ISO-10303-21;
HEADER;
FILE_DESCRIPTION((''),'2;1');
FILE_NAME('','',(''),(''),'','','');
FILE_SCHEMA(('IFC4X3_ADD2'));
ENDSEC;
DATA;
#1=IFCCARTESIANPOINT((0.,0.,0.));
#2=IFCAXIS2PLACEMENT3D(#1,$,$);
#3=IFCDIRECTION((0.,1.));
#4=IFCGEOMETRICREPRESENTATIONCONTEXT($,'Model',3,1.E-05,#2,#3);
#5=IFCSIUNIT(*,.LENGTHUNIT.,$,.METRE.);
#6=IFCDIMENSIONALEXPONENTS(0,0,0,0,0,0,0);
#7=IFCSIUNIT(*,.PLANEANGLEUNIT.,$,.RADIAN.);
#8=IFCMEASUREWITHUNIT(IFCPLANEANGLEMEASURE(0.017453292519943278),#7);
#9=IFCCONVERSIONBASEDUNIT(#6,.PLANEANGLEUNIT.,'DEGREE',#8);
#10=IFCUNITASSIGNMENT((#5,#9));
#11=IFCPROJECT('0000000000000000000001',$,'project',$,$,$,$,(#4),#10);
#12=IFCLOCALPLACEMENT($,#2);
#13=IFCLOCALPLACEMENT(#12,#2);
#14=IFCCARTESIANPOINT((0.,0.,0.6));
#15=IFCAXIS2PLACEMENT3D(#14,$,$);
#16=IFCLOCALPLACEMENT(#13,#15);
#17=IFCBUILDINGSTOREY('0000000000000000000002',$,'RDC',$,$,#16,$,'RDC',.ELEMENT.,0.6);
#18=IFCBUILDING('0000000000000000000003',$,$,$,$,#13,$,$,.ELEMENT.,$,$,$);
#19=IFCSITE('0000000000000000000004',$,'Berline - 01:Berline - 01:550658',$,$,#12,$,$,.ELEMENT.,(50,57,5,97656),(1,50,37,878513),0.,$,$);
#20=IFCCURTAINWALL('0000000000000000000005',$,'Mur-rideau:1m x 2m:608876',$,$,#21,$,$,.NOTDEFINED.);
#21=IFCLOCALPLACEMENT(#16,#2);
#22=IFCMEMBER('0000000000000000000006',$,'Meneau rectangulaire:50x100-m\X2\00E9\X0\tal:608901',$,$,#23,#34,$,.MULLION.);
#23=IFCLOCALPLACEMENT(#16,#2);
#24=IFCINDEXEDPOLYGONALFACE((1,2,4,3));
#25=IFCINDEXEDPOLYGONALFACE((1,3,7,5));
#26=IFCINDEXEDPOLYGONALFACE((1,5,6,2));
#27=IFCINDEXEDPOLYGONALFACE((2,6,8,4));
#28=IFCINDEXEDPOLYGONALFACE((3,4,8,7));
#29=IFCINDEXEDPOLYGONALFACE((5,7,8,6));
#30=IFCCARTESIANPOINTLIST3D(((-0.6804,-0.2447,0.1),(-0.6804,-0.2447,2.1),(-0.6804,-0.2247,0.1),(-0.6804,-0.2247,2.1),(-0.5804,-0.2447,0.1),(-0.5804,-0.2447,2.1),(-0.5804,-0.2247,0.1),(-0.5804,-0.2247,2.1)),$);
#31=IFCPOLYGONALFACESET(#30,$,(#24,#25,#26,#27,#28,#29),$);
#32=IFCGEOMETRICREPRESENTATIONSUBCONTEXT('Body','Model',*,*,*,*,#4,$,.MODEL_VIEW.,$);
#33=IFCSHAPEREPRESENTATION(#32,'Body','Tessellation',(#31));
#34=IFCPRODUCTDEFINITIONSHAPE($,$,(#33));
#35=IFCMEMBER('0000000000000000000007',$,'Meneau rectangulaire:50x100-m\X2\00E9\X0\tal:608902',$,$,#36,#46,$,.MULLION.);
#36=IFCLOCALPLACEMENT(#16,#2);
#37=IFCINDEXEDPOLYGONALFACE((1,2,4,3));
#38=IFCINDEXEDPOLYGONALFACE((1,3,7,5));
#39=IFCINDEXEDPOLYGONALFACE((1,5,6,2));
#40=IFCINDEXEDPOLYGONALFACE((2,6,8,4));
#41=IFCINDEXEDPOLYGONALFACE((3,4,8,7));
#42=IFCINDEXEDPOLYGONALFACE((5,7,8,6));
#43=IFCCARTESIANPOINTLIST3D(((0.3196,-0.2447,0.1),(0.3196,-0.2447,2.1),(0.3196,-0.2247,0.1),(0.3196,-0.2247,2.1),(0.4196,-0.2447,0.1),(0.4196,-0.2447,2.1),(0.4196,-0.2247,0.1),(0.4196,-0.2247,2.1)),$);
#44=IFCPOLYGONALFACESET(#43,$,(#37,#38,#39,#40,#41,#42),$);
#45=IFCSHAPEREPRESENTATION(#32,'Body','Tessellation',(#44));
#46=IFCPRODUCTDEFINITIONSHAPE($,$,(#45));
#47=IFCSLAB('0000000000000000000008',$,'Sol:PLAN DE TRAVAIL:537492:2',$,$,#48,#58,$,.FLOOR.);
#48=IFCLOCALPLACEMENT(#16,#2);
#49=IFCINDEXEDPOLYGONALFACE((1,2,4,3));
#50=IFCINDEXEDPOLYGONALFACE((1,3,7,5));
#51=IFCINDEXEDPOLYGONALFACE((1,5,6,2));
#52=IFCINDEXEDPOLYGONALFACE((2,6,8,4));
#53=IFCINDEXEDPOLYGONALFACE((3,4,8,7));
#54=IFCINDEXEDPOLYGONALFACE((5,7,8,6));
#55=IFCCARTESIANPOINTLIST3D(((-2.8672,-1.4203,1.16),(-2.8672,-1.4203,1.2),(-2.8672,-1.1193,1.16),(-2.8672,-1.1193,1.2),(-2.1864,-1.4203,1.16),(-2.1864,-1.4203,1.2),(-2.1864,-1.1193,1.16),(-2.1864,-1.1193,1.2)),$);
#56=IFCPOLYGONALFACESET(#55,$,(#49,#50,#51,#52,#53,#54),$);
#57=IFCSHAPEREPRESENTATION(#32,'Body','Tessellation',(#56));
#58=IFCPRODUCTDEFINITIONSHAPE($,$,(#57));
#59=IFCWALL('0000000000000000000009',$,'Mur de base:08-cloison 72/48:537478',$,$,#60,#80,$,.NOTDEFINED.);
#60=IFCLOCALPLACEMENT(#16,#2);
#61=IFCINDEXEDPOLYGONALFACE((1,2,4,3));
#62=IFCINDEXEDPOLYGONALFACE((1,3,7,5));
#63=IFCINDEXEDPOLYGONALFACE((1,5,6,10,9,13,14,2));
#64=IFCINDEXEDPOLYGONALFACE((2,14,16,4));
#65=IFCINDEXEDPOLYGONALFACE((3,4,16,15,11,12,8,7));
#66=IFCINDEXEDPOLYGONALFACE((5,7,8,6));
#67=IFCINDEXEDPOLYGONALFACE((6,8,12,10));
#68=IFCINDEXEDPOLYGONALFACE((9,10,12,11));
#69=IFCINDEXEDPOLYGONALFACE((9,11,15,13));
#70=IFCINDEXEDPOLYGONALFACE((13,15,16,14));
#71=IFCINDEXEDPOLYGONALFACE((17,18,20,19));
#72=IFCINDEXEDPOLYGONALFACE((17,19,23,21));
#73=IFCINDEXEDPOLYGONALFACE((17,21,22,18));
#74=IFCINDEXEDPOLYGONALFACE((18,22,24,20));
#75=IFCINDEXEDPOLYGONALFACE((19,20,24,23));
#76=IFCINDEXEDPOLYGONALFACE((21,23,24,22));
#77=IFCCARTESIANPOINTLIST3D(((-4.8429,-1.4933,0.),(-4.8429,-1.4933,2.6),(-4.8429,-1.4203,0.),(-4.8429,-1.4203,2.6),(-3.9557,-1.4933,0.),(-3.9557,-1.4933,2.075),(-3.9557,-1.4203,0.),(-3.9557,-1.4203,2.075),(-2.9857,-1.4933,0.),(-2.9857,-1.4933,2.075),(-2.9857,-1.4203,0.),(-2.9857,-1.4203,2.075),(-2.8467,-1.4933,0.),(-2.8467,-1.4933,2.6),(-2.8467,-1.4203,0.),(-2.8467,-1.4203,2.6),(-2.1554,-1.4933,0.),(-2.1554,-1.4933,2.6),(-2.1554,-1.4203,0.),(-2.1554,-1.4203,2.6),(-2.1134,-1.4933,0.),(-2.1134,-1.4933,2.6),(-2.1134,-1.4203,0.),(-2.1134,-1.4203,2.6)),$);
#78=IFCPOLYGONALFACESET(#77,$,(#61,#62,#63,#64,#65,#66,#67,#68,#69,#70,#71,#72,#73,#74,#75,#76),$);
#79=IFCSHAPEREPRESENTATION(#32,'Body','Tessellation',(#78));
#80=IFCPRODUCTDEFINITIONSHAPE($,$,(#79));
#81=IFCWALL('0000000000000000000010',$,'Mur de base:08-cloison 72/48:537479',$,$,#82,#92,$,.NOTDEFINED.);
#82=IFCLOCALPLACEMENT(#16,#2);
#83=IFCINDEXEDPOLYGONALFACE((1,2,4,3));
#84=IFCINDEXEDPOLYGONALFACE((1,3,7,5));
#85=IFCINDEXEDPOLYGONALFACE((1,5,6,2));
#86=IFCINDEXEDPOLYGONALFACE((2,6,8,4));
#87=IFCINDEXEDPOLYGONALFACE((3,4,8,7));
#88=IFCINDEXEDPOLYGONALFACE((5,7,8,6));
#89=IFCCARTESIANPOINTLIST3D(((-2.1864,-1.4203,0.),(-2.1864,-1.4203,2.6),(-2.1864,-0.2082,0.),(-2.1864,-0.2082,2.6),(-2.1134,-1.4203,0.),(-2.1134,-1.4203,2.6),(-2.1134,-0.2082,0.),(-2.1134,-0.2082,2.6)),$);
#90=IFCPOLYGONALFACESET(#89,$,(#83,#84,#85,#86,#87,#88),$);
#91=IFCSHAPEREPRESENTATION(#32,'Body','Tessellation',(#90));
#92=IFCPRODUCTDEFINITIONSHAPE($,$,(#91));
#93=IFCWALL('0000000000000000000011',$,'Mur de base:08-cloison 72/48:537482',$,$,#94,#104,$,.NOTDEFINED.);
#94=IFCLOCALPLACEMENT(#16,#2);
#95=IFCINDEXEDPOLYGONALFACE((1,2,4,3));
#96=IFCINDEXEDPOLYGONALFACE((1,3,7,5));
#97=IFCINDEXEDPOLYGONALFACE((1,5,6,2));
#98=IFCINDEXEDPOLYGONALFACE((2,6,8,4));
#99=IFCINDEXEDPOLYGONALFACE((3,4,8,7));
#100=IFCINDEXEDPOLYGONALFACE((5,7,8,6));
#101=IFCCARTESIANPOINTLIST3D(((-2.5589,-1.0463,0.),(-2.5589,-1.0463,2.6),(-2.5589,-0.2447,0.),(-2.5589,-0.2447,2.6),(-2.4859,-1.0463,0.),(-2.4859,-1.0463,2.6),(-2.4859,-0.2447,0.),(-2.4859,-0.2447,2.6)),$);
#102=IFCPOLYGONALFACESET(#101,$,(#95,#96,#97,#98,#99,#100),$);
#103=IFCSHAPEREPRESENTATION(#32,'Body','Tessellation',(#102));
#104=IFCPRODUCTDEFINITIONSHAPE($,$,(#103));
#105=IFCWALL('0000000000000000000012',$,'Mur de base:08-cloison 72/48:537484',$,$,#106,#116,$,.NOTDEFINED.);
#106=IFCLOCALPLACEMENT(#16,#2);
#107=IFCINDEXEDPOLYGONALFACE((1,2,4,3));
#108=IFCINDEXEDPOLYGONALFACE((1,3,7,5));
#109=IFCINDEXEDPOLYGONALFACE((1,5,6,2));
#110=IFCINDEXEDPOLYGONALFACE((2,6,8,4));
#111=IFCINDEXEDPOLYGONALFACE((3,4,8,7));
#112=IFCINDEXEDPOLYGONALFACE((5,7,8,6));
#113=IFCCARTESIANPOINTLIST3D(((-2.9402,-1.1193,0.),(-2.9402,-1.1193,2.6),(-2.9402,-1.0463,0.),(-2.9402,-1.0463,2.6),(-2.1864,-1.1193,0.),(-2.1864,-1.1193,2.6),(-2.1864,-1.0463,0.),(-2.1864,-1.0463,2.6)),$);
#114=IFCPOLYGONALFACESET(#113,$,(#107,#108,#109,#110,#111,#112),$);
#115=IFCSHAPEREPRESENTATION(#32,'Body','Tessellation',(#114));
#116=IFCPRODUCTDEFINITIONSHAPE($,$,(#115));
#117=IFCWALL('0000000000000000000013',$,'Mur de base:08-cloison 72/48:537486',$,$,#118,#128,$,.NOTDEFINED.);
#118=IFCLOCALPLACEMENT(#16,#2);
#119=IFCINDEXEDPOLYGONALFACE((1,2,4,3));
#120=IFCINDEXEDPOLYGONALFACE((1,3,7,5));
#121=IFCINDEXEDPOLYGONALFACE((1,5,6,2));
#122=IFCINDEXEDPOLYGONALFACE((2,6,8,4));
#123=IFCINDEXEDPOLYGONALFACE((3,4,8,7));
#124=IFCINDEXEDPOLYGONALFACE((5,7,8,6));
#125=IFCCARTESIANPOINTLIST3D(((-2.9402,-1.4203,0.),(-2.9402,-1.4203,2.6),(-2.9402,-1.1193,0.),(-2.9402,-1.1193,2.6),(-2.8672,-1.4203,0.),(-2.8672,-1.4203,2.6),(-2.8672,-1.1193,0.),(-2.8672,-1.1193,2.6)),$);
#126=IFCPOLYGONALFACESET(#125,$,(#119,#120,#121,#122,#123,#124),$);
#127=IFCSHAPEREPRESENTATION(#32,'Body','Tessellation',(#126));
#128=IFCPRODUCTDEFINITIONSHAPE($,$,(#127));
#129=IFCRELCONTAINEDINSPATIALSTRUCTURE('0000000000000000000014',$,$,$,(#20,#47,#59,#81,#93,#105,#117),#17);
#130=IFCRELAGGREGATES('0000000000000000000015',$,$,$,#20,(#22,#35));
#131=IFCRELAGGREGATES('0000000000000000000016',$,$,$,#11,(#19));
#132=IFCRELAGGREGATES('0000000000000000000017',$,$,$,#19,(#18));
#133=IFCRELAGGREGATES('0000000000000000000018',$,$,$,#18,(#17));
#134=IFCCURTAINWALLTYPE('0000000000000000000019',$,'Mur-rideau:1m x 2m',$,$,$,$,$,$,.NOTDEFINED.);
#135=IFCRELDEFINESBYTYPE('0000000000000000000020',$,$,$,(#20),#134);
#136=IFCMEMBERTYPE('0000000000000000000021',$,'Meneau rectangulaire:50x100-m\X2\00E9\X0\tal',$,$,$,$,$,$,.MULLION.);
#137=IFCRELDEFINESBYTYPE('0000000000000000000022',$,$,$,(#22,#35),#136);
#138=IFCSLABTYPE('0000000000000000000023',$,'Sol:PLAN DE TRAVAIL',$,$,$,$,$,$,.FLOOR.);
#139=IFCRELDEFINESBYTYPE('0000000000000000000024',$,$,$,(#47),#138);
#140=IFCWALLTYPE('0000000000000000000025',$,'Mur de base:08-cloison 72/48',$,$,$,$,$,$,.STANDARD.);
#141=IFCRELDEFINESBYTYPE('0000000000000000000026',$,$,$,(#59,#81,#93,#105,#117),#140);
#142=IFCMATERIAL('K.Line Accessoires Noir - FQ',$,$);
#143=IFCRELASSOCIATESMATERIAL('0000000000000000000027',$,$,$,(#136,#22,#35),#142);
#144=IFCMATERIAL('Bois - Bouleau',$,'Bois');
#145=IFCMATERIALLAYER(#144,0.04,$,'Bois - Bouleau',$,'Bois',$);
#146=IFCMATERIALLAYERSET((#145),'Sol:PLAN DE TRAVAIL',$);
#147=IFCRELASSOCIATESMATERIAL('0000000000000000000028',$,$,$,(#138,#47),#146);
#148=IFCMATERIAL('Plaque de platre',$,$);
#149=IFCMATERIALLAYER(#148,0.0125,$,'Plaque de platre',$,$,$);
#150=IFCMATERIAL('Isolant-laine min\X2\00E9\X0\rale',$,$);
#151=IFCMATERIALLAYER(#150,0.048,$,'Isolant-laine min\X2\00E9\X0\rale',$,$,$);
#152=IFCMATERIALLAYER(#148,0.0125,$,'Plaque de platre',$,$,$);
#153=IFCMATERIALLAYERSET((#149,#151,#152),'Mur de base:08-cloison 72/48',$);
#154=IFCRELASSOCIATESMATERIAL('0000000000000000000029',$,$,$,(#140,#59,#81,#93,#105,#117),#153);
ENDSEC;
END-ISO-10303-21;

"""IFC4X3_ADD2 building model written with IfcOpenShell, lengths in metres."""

from ifc_helpers import new_model, entity, si_unit, converted_unit, direction, frame, frame_2d, origin, origin_2d_with_axis, place, context, subcontext, project, spatial, rectangle, extrude, source, transform, mapped, material, layer, layer_set, layer_usage, material_profile, profile_set, profile_usage, type_object, type_shapes, element, aggregate, save


model = new_model("IFC4X3_ADD2")

# Units and contexts
model_context = context("Model", 3, precision=1e-05, world=origin(), true_north=direction((0.0, 1.0)))
body_context = subcontext(model_context, "Body", "Model", "MODEL_VIEW")
ifc_project = project(units=[si_unit("LENGTHUNIT", "METRE"), converted_unit("PLANEANGLEUNIT", "DEGREE", entity("IfcPlaneAngleMeasure", 0.017453292519943278), si_unit("PLANEANGLEUNIT", "RADIAN"), dimensions=[0, 0, 0, 0, 0, 0, 0])], contexts=[model_context])

# Site, building, storey
site_placement = place(None, origin())
site = spatial("IfcSite", under=ifc_project, at=site_placement, Name="Berline - 01:Berline - 01:550658", CompositionType="ELEMENT", RefLatitude=(50, 57, 5, 97656), RefLongitude=(1, 50, 37, 878513), RefElevation=0.0)
building_placement = place(site_placement, origin())
building = spatial("IfcBuilding", under=site, at=building_placement, CompositionType="ELEMENT")
storey_placement = place(building_placement, frame((0.0, 0.0, 0.6)))
storey = spatial("IfcBuildingStorey", under=building, at=storey_placement, Name="RDC", LongName="RDC", CompositionType="ELEMENT", Elevation=0.6)

# Curtain wall, members
ifc_material_1 = material(Name="K.Line Accessoires Noir - FQ")
ifc_material_profile = material_profile(ifc_material_1, rectangle(XDim=0.1, YDim=0.02, at=origin_2d_with_axis()), Name="50x100-métal")
ifc_profile_set = profile_set([ifc_material_profile], Name="50x100-métal")
ifc_profile_usage = profile_usage(ifc_profile_set)
curtain_wall_type_1 = type_object("IfcCurtainWallType", Name="Mur-rideau:1m x 2m", PredefinedType="NOTDEFINED")
curtain_wall_1_placement = place(storey_placement, frame((0.0, 0.0, -0.6)))
curtain_wall_1 = element("IfcCurtainWall", 1, at=curtain_wall_1_placement, inside=storey, type_object=curtain_wall_type_1, Name="Mur-rideau:1m x 2m:608876", PredefinedType="NOTDEFINED")
member_type_1 = type_object("IfcMemberType", Name="Meneau rectangulaire:50x100-métal", PredefinedType="MULLION", material=ifc_profile_set)
shared_shape_1 = source(origin(), body_context, "Body", "SweptSolid", [
    extrude(rectangle(XDim=0.02, YDim=0.1, at=origin_2d_with_axis()), frame((0.05, -0.01, -2.0), z_axis=(0.0, 0.0, 1.0), x_axis=(0.0, 1.0, 0.0)), (0.0, 0.0, 1.0), 2.0),
])
type_shapes(member_type_1, [shared_shape_1])
member_1_placement = place(curtain_wall_1_placement, frame((-0.6804, -0.2447, 0.7), z_axis=(0.0, 0.0, -1.0), x_axis=(1.0, 0.0, 0.0)))
member_1 = element("IfcMember", 2, at=member_1_placement, type_object=member_type_1, material=ifc_profile_usage, Name="Meneau rectangulaire:50x100-métal:608901", PredefinedType="MULLION", context=body_context, shape_type="MappedRepresentation", body=[
    mapped(shared_shape_1, transform((0.0, 0.0, 0.0), scale=1.0)),
])
member_2_placement = place(curtain_wall_1_placement, frame((0.3196, -0.2447, 0.7), z_axis=(0.0, 0.0, -1.0), x_axis=(1.0, 0.0, 0.0)))
member_2 = element("IfcMember", 3, at=member_2_placement, type_object=member_type_1, material=ifc_profile_usage, Name="Meneau rectangulaire:50x100-métal:608902", PredefinedType="MULLION", context=body_context, shape_type="MappedRepresentation", body=[
    mapped(shared_shape_1, transform((0.0, 0.0, 0.0), scale=1.0)),
])

# Slab
ifc_material_2 = material(Name="Bois - Bouleau", Category="Bois")
ifc_layer_1 = layer(ifc_material_2, 0.04, Name="Bois - Bouleau", Category="Bois")
ifc_layer_set_1 = layer_set([ifc_layer_1], Name="Sol:PLAN DE TRAVAIL")
ifc_layer_usage_1 = layer_usage(ifc_layer_set_1, "AXIS3", "POSITIVE", 0.0)
slab_type = type_object("IfcSlabType", Name="Sol:PLAN DE TRAVAIL", PredefinedType="FLOOR", material=ifc_layer_set_1)
slab_1_placement = place(storey_placement, frame((-2.8672, -1.4203, 1.16)))
element("IfcSlab", 4, at=slab_1_placement, inside=storey, type_object=slab_type, material=ifc_layer_usage_1, Name="Sol:PLAN DE TRAVAIL:537492:2", PredefinedType="FLOOR", context=body_context, shape_type="SweptSolid", body=[
    extrude(rectangle(XDim=0.301, YDim=0.6808, at=frame_2d((0.0, -0.4373), x_axis=(0.0, -1.0))), frame((0.3404, 0.5878, 0.04), z_axis=(0.0, 0.0, -1.0), x_axis=(-1.0, 0.0, 0.0)), (0.0, 0.0, 1.0), 0.04),
])

aggregate(curtain_wall_1, [member_1, member_2])

# Wall, openings
ifc_material_3 = material(Name="Plaque de platre")
ifc_layer_2 = layer(ifc_material_3, 0.0125, Name="Plaque de platre")
ifc_material_4 = material(Name="Isolant-laine minérale")
ifc_layer_3 = layer(ifc_material_4, 0.048, Name="Isolant-laine minérale")
ifc_layer_4 = layer(ifc_material_3, 0.0125, Name="Plaque de platre")
ifc_layer_set_2 = layer_set([ifc_layer_2, ifc_layer_3, ifc_layer_4], Name="Mur de base:08-cloison 72/48")
wall_type = type_object("IfcWallType", Name="Mur de base:08-cloison 72/48", PredefinedType="STANDARD", material=ifc_layer_set_2)
wall_1_placement = place(storey_placement, frame((-4.8429, -1.4568, 0.0)))
wall_1 = element("IfcWall", 5, at=wall_1_placement, inside=storey, type_object=wall_type, material=ifc_layer_set_2, Name="Mur de base:08-cloison 72/48:537478", PredefinedType="NOTDEFINED", context=body_context, shape_type="SweptSolid", body=[
    extrude(rectangle(XDim=2.7295, YDim=0.073, at=frame_2d((1.3648, 0.0), x_axis=(-1.0, 0.0))), origin(), (0.0, 0.0, 1.0), 2.6),
])
opening_1_placement = place(wall_1_placement, frame((1.9962, -0.0365, 0.0)))
element("IfcOpeningElement", 6, at=opening_1_placement, cuts=wall_1, PredefinedType="OPENING", context=body_context, shape_type="SweptSolid", body=[
    extrude(rectangle(XDim=2.6384, YDim=0.6913, at=origin_2d_with_axis()), frame((0.3456, 0.0, 1.3192), z_axis=(0.0, 1.0, 0.0), x_axis=(0.0, 0.0, -1.0)), (0.0, 0.0, 1.0), 0.073),
])
opening_2_placement = place(wall_1_placement, frame((1.8572, 0.0365, 0.0)))
element("IfcOpeningElement", 7, at=opening_2_placement, cuts=wall_1, PredefinedType="OPENING", context=body_context, shape_type="SweptSolid", body=[
    extrude(rectangle(XDim=2.075, YDim=0.97, at=frame_2d((1.0375, 0.485), x_axis=(1.0, 0.0))), frame((0.0, 0.0, 0.0), z_axis=(0.0, -1.0, 0.0), x_axis=(0.0, 0.0, 1.0)), (0.0, 0.0, 1.0), 0.073),
])

# Walls
wall_2_placement = place(storey_placement, frame((-2.1499, -0.2082, 0.0), z_axis=(0.0, 0.0, 1.0), x_axis=(0.0, -1.0, 0.0)))
element("IfcWall", 8, at=wall_2_placement, inside=storey, type_object=wall_type, material=ifc_layer_set_2, Name="Mur de base:08-cloison 72/48:537479", PredefinedType="NOTDEFINED", context=body_context, shape_type="SweptSolid", body=[
    extrude(rectangle(XDim=1.2121, YDim=0.073, at=frame_2d((0.6061, 0.0), x_axis=(-1.0, 0.0))), origin(), (0.0, 0.0, 1.0), 2.6),
])
wall_3_placement = place(storey_placement, frame((-2.5224, -0.2447, 0.0), z_axis=(0.0, 0.0, 1.0), x_axis=(0.0, -1.0, 0.0)))
element("IfcWall", 9, at=wall_3_placement, inside=storey, type_object=wall_type, material=ifc_layer_set_2, Name="Mur de base:08-cloison 72/48:537482", PredefinedType="NOTDEFINED", context=body_context, shape_type="SweptSolid", body=[
    extrude(rectangle(XDim=0.8016, YDim=0.073, at=frame_2d((0.4008, 0.0), x_axis=(-1.0, 0.0))), origin(), (0.0, 0.0, 1.0), 2.6),
])
wall_4_placement = place(storey_placement, frame((-2.1864, -1.0828, 0.0), z_axis=(0.0, 0.0, 1.0), x_axis=(-1.0, 0.0, 0.0)))
element("IfcWall", 10, at=wall_4_placement, inside=storey, type_object=wall_type, material=ifc_layer_set_2, Name="Mur de base:08-cloison 72/48:537484", PredefinedType="NOTDEFINED", context=body_context, shape_type="SweptSolid", body=[
    extrude(rectangle(XDim=0.7538, YDim=0.073, at=frame_2d((0.3769, 0.0), x_axis=(-1.0, 0.0))), origin(), (0.0, 0.0, 1.0), 2.6),
])
wall_5_placement = place(storey_placement, frame((-2.9037, -1.1193, 0.0), z_axis=(0.0, 0.0, 1.0), x_axis=(0.0, -1.0, 0.0)))
element("IfcWall", 11, at=wall_5_placement, inside=storey, type_object=wall_type, material=ifc_layer_set_2, Name="Mur de base:08-cloison 72/48:537486", PredefinedType="NOTDEFINED", context=body_context, shape_type="SweptSolid", body=[
    extrude(rectangle(XDim=0.301, YDim=0.073, at=frame_2d((0.1505, 0.0), x_axis=(-1.0, 0.0))), origin(), (0.0, 0.0, 1.0), 2.6),
])

save(model, "model.ifc")
